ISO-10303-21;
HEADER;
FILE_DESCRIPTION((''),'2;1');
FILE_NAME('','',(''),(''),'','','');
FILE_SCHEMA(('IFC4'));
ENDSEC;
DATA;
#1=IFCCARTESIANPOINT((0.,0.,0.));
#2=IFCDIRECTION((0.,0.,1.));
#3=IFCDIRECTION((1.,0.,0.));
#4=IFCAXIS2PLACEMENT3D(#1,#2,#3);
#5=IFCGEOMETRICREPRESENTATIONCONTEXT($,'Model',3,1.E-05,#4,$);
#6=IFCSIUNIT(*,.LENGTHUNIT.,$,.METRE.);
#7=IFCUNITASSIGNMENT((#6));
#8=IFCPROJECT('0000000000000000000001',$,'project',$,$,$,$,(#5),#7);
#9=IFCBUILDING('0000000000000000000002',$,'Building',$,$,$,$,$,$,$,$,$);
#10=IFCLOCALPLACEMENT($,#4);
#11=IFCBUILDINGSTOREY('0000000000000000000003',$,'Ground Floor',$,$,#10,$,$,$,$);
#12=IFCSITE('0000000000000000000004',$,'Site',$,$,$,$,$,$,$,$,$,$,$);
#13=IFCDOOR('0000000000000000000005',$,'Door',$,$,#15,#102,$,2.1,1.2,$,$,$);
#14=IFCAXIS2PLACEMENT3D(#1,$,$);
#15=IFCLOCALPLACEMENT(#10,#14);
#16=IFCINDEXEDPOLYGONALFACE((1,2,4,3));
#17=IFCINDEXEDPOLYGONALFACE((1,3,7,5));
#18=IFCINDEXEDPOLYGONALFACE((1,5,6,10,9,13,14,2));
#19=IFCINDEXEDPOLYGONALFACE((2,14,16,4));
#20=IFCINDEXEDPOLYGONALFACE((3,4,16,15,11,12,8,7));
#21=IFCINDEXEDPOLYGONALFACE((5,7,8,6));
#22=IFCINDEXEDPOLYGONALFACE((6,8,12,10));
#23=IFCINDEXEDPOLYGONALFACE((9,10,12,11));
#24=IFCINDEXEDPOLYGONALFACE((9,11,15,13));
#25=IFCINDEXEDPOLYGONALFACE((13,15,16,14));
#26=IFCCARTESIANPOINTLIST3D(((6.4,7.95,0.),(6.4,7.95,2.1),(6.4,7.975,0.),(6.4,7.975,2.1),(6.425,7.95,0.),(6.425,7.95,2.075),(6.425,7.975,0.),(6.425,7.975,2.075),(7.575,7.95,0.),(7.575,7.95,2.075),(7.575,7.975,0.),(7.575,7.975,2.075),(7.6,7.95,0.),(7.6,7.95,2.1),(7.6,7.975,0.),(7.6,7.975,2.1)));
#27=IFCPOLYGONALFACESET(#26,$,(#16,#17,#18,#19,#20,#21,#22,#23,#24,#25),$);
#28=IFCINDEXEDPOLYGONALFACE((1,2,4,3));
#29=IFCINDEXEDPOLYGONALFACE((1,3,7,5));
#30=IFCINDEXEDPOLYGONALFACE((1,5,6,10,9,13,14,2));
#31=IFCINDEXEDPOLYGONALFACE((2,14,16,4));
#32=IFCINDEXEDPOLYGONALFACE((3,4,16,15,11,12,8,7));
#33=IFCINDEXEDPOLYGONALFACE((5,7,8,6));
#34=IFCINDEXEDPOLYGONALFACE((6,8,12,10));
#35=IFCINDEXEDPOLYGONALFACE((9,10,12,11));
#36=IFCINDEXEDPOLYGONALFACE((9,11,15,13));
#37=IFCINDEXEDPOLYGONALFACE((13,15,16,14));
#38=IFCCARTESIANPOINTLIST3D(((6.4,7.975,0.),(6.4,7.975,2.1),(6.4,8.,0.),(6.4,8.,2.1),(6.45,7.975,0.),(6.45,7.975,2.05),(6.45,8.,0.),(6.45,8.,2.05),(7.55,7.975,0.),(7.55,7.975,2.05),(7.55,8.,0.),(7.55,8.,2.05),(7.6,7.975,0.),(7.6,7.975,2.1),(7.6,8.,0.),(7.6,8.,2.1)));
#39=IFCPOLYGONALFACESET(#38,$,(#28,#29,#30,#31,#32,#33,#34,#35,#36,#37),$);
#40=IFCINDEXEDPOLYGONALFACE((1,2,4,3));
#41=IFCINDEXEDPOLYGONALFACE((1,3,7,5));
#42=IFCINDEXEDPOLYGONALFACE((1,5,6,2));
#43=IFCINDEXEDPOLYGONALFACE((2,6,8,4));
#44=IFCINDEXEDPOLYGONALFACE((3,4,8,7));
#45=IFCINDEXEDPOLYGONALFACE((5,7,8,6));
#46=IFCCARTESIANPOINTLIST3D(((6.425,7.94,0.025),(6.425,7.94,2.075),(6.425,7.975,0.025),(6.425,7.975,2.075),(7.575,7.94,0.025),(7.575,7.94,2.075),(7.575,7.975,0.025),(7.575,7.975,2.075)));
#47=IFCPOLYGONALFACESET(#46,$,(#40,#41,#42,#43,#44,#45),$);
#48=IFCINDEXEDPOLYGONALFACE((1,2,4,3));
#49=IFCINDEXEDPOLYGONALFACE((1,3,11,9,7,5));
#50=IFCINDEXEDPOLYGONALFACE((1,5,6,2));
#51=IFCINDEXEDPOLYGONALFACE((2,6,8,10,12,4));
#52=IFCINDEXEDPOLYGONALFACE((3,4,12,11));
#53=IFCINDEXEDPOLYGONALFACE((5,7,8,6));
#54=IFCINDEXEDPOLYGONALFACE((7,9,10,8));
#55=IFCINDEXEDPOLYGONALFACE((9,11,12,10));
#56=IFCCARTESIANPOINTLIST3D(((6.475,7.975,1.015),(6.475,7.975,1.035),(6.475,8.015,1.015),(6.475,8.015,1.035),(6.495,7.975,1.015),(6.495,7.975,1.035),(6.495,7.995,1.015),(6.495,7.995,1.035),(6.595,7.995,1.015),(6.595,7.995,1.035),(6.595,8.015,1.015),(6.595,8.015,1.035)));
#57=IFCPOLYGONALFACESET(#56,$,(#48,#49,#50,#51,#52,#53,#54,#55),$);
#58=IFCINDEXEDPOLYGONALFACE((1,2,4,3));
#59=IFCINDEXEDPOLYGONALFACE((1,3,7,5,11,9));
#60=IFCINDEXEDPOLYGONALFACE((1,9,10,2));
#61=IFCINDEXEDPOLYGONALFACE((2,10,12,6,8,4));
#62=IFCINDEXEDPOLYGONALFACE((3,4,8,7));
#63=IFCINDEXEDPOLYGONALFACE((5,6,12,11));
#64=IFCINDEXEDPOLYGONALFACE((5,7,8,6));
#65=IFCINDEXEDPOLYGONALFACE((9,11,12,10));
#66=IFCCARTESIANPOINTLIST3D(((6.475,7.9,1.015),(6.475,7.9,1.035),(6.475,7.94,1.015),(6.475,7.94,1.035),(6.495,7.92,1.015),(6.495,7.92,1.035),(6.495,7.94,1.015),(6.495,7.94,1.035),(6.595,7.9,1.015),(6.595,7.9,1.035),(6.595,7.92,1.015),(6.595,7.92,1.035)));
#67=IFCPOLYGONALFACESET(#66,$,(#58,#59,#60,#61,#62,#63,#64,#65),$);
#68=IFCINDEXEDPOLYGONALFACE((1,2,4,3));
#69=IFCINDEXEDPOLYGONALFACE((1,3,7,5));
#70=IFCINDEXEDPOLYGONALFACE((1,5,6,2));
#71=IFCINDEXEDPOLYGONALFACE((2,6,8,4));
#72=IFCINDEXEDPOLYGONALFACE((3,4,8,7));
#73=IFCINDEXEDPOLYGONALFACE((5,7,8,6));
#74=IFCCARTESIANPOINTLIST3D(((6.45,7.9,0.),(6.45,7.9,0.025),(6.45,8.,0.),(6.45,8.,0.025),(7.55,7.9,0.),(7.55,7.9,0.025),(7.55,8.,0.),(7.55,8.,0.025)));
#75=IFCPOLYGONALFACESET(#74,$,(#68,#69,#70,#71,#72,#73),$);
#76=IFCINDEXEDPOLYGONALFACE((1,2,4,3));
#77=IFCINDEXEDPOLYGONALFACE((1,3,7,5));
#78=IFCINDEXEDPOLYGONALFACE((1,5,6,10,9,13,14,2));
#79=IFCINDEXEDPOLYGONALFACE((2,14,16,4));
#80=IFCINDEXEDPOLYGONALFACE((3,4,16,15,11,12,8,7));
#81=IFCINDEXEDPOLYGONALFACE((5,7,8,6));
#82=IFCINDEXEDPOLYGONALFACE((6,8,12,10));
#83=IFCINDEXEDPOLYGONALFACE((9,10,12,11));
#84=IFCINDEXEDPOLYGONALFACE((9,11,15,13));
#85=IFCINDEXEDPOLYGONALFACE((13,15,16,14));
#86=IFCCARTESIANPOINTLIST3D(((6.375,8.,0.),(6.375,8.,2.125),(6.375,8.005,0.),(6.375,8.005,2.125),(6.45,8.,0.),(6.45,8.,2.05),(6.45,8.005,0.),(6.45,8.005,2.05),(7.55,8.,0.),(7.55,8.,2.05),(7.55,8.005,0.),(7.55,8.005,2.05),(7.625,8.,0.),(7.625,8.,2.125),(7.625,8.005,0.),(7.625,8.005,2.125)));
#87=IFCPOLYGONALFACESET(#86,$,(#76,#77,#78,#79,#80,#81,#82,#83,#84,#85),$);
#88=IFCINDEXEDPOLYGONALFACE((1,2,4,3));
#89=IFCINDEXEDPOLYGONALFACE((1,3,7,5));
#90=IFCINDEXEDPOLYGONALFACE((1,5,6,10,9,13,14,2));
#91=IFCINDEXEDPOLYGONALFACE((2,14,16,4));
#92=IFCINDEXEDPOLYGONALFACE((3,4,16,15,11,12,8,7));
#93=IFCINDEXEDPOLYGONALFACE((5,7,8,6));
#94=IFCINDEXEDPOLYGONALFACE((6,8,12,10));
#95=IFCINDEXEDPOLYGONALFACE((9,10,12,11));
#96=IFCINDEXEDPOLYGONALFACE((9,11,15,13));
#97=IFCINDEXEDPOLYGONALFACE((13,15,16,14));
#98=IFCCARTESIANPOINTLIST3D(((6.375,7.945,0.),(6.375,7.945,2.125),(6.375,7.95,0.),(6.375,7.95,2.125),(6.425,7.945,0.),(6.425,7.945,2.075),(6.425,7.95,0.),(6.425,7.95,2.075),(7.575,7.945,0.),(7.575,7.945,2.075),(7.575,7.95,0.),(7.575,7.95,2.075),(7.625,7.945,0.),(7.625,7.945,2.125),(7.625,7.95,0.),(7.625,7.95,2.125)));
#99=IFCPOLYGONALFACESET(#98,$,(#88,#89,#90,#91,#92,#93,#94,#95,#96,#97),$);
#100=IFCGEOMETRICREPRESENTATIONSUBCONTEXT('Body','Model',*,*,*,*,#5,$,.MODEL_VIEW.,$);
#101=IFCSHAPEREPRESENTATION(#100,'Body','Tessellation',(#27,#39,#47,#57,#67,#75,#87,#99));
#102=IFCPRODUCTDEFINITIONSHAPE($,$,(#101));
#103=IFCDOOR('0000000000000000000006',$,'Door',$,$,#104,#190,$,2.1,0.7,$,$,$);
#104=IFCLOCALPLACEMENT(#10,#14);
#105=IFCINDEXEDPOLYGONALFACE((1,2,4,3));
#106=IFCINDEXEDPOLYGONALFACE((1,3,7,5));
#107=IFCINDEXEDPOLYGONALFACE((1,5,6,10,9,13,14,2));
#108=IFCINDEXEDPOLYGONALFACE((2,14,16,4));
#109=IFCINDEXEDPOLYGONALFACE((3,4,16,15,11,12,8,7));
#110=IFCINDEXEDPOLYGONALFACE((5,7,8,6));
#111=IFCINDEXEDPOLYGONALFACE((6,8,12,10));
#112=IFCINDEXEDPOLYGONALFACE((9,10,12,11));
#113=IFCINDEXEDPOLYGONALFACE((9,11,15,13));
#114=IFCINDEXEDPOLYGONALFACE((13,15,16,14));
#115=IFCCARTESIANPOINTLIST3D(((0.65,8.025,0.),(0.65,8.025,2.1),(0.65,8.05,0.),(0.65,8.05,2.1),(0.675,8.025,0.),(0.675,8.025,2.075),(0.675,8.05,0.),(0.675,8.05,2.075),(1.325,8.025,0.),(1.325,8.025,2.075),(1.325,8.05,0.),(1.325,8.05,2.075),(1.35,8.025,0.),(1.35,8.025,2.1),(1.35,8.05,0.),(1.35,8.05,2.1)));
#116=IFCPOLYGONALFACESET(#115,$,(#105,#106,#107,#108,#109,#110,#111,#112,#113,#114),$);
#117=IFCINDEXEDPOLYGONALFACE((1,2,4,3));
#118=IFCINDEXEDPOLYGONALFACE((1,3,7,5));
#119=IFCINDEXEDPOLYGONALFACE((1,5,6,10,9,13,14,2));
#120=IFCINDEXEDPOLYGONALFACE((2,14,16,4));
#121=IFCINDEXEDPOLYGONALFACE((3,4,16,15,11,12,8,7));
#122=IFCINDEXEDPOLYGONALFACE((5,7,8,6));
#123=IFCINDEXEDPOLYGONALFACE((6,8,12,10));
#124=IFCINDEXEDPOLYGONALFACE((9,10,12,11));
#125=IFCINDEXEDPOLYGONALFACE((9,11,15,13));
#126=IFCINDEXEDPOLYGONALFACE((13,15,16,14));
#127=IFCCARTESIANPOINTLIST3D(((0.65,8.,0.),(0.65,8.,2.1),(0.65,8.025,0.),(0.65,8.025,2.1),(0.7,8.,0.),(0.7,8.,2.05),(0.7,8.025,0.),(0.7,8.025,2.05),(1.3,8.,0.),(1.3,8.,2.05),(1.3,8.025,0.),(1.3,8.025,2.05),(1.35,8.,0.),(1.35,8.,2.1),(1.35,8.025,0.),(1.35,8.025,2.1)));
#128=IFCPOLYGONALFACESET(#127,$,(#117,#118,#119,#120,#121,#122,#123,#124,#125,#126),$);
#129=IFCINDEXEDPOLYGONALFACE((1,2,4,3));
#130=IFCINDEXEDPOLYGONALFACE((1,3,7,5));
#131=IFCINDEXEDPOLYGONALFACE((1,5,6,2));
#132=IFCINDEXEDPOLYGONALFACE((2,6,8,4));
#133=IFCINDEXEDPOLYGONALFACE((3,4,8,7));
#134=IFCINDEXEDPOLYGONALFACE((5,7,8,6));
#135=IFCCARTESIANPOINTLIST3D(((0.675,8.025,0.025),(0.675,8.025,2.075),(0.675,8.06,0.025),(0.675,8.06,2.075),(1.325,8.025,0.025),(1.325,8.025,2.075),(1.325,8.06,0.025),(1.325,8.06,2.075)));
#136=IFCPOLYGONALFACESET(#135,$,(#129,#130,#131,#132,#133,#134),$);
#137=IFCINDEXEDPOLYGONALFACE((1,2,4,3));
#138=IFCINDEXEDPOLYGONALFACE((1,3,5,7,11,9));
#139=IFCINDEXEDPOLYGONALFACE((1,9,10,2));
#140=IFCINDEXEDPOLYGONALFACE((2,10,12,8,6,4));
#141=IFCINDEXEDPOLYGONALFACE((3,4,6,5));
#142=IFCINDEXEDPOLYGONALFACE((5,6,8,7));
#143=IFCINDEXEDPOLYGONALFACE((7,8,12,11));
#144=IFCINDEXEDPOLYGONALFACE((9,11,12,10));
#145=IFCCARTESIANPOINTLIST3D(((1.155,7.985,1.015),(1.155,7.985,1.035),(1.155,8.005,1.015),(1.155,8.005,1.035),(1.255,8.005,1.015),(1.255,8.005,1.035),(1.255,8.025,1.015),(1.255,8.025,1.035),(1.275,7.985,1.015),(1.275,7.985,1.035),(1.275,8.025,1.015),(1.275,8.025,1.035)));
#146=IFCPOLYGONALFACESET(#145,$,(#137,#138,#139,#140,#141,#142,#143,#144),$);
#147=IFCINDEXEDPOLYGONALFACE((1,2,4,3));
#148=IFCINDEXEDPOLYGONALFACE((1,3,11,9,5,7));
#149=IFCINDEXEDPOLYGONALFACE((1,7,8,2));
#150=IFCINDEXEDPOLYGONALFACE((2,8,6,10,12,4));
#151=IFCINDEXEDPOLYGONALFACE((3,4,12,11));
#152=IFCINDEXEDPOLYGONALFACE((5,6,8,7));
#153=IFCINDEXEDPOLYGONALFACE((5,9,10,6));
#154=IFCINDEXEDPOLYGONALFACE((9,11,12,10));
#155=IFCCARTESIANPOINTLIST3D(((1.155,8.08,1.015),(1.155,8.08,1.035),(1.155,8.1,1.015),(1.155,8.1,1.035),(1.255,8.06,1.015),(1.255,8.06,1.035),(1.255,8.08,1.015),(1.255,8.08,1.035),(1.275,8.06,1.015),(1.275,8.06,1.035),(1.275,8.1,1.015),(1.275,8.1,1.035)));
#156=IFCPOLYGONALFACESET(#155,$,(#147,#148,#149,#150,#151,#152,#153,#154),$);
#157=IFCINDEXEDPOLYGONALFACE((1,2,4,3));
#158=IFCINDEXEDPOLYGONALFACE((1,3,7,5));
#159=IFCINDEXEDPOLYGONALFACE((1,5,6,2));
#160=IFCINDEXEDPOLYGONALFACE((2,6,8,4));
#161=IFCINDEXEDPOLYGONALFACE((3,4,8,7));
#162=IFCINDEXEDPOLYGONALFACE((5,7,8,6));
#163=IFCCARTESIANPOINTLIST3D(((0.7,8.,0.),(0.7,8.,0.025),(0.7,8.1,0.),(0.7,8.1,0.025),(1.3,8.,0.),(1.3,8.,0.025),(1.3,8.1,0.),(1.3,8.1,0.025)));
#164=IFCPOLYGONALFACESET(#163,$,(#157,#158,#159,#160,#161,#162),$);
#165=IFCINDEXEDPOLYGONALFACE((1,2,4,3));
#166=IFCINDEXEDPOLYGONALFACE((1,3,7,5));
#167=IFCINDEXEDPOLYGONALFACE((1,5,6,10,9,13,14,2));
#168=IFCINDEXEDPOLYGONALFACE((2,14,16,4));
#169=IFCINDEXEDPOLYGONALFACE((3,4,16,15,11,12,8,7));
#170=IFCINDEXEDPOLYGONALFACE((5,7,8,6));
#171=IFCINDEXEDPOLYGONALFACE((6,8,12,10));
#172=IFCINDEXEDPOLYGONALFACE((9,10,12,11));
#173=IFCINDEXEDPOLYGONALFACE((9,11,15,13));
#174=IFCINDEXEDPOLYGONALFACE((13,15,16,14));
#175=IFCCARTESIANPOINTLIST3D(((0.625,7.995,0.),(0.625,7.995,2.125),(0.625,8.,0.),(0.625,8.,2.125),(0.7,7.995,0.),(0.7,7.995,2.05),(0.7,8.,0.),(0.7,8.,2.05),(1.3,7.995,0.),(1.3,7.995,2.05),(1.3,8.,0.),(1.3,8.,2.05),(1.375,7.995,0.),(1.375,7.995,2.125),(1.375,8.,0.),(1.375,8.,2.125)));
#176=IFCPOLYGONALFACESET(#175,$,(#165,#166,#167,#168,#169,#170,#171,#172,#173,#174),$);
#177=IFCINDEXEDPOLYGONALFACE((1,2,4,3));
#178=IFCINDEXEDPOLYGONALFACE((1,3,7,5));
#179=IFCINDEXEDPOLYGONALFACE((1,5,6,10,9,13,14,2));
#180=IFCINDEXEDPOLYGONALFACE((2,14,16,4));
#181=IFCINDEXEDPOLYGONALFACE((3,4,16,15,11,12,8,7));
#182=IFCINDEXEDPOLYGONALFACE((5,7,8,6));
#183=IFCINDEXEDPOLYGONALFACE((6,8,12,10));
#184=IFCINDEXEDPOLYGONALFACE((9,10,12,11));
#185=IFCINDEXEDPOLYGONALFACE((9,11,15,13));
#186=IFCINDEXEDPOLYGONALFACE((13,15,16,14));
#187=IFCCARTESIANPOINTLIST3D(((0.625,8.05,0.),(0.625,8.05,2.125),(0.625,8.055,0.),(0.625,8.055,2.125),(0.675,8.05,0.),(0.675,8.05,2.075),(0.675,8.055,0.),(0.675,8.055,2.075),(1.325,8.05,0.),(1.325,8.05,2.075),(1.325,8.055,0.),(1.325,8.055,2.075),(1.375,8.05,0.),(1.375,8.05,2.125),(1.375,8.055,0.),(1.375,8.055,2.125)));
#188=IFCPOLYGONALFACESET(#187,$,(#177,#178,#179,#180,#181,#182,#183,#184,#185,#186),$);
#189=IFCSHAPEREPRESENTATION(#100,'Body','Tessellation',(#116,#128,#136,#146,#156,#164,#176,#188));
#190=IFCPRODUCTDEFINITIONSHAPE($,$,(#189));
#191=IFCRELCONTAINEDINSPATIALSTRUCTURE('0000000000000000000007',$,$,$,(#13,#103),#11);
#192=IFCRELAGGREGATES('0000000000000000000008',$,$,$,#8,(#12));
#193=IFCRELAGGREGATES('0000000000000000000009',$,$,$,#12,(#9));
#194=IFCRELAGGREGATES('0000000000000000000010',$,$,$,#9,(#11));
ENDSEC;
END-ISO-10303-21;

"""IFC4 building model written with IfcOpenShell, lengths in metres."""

from ifc_helpers import new_model, si_unit, frame, origin_with_axes, place, context, subcontext, project, spatial, line, indexed_curve, outline, extrude, element, save


model = new_model("IFC4")

# Units and contexts
model_context = context("Model", 3, precision=1e-05, world=origin_with_axes())
body_context = subcontext(model_context, "Body", "Model", "MODEL_VIEW")
ifc_project = project(units=[si_unit("LENGTHUNIT", "METRE")], contexts=[model_context])

# Site, building, storey
site = spatial("IfcSite", under=ifc_project, Name="Site")
building = spatial("IfcBuilding", under=site, Name="Building")
storey_placement = place(None, origin_with_axes())
storey = spatial("IfcBuildingStorey", under=building, at=storey_placement, Name="Ground Floor")

# Doors
door_1_placement = place(storey_placement, frame((7.6, 8.0, 0.0), z_axis=(0.0, 0.0, 1.0), x_axis=(-1.0, 0.0, 0.0)))
element("IfcDoor", 1, at=door_1_placement, inside=storey, Name="Door", OverallHeight=2.1, OverallWidth=1.2, context=body_context, shape_type="SweptSolid", body=[
    extrude(outline(indexed_curve([(0.0, 0.0), (0.0, 2.1), (1.2, 2.1), (1.2, 0.0), (1.175, 0.0), (1.175, 2.075), (0.025, 2.075), (0.025, 0.0)], segments=[line(1, 2, 3, 4, 5, 6, 7, 8, 1)])), frame((0.0, 0.025, 0.0), z_axis=(0.0, -1.0, 0.0), x_axis=(1.0, 0.0, 0.0)), (0.0, 0.0, -1.0), 0.025),
    extrude(outline(indexed_curve([(0.0, 0.0), (0.0, 2.1), (1.2, 2.1), (1.2, 0.0), (1.15, 0.0), (1.15, 2.05), (0.05, 2.05), (0.05, 0.0)], segments=[line(1, 2, 3, 4, 5, 6, 7, 8, 1)])), frame((0.0, 0.0, 0.0), z_axis=(0.0, -1.0, 0.0), x_axis=(1.0, 0.0, 0.0)), (0.0, 0.0, -1.0), 0.025),
    extrude(outline(indexed_curve([(0.0, 0.0), (1.15, 0.0), (1.15, 0.035), (0.0, 0.035)], segments=[line(1, 2, 3, 4, 1)])), frame((0.025, 0.025, 0.025), z_axis=(0.0, 0.0, 1.0), x_axis=(1.0, 0.0, 0.0)), (0.0, 0.0, 1.0), 2.05),
    extrude(outline(indexed_curve([(0.0, 0.0), (0.0, -0.04), (-0.12, -0.04), (-0.12, -0.02), (-0.02, -0.02), (-0.02, 0.0)], segments=[line(1, 2, 3, 4, 5, 6, 1)])), frame((1.125, 0.025, 1.015), z_axis=(0.0, 0.0, 1.0), x_axis=(1.0, 0.0, 0.0)), (0.0, 0.0, 1.0), 0.02),
    extrude(outline(indexed_curve([(0.0, 0.0), (0.0, 0.04), (-0.12, 0.04), (-0.12, 0.02), (-0.02, 0.02), (-0.02, 0.0)], segments=[line(1, 2, 3, 4, 5, 6, 1)])), frame((1.125, 0.06, 1.015), z_axis=(0.0, 0.0, 1.0), x_axis=(1.0, 0.0, 0.0)), (0.0, 0.0, 1.0), 0.02),
    extrude(outline(indexed_curve([(0.0, 0.0), (1.1, 0.0), (1.1, 0.1), (0.0, 0.1)], segments=[line(1, 2, 3, 4, 1)])), frame((0.05, 0.0, 0.0), z_axis=(0.0, 0.0, 1.0), x_axis=(1.0, 0.0, 0.0)), (0.0, 0.0, 1.0), 0.025),
    extrude(outline(indexed_curve([(0.0, 0.0), (0.0, 2.125), (1.25, 2.125), (1.25, 0.0), (1.175, 0.0), (1.175, 2.05), (0.075, 2.05), (0.075, 0.0)], segments=[line(1, 2, 3, 4, 5, 6, 7, 8, 1)])), frame((-0.025, -0.005, 0.0), z_axis=(0.0, -1.0, 0.0), x_axis=(1.0, 0.0, 0.0)), (0.0, 0.0, -1.0), 0.005),
    extrude(outline(indexed_curve([(0.0, 0.0), (0.0, 2.125), (1.25, 2.125), (1.25, 0.0), (1.2, 0.0), (1.2, 2.075), (0.05, 2.075), (0.05, 0.0)], segments=[line(1, 2, 3, 4, 5, 6, 7, 8, 1)])), frame((-0.025, 0.05, 0.0), z_axis=(0.0, -1.0, 0.0), x_axis=(1.0, 0.0, 0.0)), (0.0, 0.0, -1.0), 0.005),
])
door_2_placement = place(storey_placement, frame((0.65, 8.0, 0.0), z_axis=(0.0, 0.0, 1.0), x_axis=(1.0, 0.0, 0.0)))
element("IfcDoor", 2, at=door_2_placement, inside=storey, Name="Door", OverallHeight=2.1, OverallWidth=0.7, context=body_context, shape_type="SweptSolid", body=[
    extrude(outline(indexed_curve([(0.0, 0.0), (0.0, 2.1), (0.7, 2.1), (0.7, 0.0), (0.675, 0.0), (0.675, 2.075), (0.025, 2.075), (0.025, 0.0)], segments=[line(1, 2, 3, 4, 5, 6, 7, 8, 1)])), frame((0.0, 0.025, 0.0), z_axis=(0.0, -1.0, 0.0), x_axis=(1.0, 0.0, 0.0)), (0.0, 0.0, -1.0), 0.025),
    extrude(outline(indexed_curve([(0.0, 0.0), (0.0, 2.1), (0.7, 2.1), (0.7, 0.0), (0.65, 0.0), (0.65, 2.05), (0.05, 2.05), (0.05, 0.0)], segments=[line(1, 2, 3, 4, 5, 6, 7, 8, 1)])), frame((0.0, 0.0, 0.0), z_axis=(0.0, -1.0, 0.0), x_axis=(1.0, 0.0, 0.0)), (0.0, 0.0, -1.0), 0.025),
    extrude(outline(indexed_curve([(0.0, 0.0), (0.65, 0.0), (0.65, 0.035), (0.0, 0.035)], segments=[line(1, 2, 3, 4, 1)])), frame((0.025, 0.025, 0.025), z_axis=(0.0, 0.0, 1.0), x_axis=(1.0, 0.0, 0.0)), (0.0, 0.0, 1.0), 2.05),
    extrude(outline(indexed_curve([(0.0, 0.0), (0.0, -0.04), (-0.12, -0.04), (-0.12, -0.02), (-0.02, -0.02), (-0.02, 0.0)], segments=[line(1, 2, 3, 4, 5, 6, 1)])), frame((0.625, 0.025, 1.015), z_axis=(0.0, 0.0, 1.0), x_axis=(1.0, 0.0, 0.0)), (0.0, 0.0, 1.0), 0.02),
    extrude(outline(indexed_curve([(0.0, 0.0), (0.0, 0.04), (-0.12, 0.04), (-0.12, 0.02), (-0.02, 0.02), (-0.02, 0.0)], segments=[line(1, 2, 3, 4, 5, 6, 1)])), frame((0.625, 0.06, 1.015), z_axis=(0.0, 0.0, 1.0), x_axis=(1.0, 0.0, 0.0)), (0.0, 0.0, 1.0), 0.02),
    extrude(outline(indexed_curve([(0.0, 0.0), (0.6, 0.0), (0.6, 0.1), (0.0, 0.1)], segments=[line(1, 2, 3, 4, 1)])), frame((0.05, 0.0, 0.0), z_axis=(0.0, 0.0, 1.0), x_axis=(1.0, 0.0, 0.0)), (0.0, 0.0, 1.0), 0.025),
    extrude(outline(indexed_curve([(0.0, 0.0), (0.0, 2.125), (0.75, 2.125), (0.75, 0.0), (0.675, 0.0), (0.675, 2.05), (0.075, 2.05), (0.075, 0.0)], segments=[line(1, 2, 3, 4, 5, 6, 7, 8, 1)])), frame((-0.025, -0.005, 0.0), z_axis=(0.0, -1.0, 0.0), x_axis=(1.0, 0.0, 0.0)), (0.0, 0.0, -1.0), 0.005),
    extrude(outline(indexed_curve([(0.0, 0.0), (0.0, 2.125), (0.75, 2.125), (0.75, 0.0), (0.7, 0.0), (0.7, 2.075), (0.05, 2.075), (0.05, 0.0)], segments=[line(1, 2, 3, 4, 5, 6, 7, 8, 1)])), frame((-0.025, 0.05, 0.0), z_axis=(0.0, -1.0, 0.0), x_axis=(1.0, 0.0, 0.0)), (0.0, 0.0, -1.0), 0.005),
])

save(model, "model.ifc")
